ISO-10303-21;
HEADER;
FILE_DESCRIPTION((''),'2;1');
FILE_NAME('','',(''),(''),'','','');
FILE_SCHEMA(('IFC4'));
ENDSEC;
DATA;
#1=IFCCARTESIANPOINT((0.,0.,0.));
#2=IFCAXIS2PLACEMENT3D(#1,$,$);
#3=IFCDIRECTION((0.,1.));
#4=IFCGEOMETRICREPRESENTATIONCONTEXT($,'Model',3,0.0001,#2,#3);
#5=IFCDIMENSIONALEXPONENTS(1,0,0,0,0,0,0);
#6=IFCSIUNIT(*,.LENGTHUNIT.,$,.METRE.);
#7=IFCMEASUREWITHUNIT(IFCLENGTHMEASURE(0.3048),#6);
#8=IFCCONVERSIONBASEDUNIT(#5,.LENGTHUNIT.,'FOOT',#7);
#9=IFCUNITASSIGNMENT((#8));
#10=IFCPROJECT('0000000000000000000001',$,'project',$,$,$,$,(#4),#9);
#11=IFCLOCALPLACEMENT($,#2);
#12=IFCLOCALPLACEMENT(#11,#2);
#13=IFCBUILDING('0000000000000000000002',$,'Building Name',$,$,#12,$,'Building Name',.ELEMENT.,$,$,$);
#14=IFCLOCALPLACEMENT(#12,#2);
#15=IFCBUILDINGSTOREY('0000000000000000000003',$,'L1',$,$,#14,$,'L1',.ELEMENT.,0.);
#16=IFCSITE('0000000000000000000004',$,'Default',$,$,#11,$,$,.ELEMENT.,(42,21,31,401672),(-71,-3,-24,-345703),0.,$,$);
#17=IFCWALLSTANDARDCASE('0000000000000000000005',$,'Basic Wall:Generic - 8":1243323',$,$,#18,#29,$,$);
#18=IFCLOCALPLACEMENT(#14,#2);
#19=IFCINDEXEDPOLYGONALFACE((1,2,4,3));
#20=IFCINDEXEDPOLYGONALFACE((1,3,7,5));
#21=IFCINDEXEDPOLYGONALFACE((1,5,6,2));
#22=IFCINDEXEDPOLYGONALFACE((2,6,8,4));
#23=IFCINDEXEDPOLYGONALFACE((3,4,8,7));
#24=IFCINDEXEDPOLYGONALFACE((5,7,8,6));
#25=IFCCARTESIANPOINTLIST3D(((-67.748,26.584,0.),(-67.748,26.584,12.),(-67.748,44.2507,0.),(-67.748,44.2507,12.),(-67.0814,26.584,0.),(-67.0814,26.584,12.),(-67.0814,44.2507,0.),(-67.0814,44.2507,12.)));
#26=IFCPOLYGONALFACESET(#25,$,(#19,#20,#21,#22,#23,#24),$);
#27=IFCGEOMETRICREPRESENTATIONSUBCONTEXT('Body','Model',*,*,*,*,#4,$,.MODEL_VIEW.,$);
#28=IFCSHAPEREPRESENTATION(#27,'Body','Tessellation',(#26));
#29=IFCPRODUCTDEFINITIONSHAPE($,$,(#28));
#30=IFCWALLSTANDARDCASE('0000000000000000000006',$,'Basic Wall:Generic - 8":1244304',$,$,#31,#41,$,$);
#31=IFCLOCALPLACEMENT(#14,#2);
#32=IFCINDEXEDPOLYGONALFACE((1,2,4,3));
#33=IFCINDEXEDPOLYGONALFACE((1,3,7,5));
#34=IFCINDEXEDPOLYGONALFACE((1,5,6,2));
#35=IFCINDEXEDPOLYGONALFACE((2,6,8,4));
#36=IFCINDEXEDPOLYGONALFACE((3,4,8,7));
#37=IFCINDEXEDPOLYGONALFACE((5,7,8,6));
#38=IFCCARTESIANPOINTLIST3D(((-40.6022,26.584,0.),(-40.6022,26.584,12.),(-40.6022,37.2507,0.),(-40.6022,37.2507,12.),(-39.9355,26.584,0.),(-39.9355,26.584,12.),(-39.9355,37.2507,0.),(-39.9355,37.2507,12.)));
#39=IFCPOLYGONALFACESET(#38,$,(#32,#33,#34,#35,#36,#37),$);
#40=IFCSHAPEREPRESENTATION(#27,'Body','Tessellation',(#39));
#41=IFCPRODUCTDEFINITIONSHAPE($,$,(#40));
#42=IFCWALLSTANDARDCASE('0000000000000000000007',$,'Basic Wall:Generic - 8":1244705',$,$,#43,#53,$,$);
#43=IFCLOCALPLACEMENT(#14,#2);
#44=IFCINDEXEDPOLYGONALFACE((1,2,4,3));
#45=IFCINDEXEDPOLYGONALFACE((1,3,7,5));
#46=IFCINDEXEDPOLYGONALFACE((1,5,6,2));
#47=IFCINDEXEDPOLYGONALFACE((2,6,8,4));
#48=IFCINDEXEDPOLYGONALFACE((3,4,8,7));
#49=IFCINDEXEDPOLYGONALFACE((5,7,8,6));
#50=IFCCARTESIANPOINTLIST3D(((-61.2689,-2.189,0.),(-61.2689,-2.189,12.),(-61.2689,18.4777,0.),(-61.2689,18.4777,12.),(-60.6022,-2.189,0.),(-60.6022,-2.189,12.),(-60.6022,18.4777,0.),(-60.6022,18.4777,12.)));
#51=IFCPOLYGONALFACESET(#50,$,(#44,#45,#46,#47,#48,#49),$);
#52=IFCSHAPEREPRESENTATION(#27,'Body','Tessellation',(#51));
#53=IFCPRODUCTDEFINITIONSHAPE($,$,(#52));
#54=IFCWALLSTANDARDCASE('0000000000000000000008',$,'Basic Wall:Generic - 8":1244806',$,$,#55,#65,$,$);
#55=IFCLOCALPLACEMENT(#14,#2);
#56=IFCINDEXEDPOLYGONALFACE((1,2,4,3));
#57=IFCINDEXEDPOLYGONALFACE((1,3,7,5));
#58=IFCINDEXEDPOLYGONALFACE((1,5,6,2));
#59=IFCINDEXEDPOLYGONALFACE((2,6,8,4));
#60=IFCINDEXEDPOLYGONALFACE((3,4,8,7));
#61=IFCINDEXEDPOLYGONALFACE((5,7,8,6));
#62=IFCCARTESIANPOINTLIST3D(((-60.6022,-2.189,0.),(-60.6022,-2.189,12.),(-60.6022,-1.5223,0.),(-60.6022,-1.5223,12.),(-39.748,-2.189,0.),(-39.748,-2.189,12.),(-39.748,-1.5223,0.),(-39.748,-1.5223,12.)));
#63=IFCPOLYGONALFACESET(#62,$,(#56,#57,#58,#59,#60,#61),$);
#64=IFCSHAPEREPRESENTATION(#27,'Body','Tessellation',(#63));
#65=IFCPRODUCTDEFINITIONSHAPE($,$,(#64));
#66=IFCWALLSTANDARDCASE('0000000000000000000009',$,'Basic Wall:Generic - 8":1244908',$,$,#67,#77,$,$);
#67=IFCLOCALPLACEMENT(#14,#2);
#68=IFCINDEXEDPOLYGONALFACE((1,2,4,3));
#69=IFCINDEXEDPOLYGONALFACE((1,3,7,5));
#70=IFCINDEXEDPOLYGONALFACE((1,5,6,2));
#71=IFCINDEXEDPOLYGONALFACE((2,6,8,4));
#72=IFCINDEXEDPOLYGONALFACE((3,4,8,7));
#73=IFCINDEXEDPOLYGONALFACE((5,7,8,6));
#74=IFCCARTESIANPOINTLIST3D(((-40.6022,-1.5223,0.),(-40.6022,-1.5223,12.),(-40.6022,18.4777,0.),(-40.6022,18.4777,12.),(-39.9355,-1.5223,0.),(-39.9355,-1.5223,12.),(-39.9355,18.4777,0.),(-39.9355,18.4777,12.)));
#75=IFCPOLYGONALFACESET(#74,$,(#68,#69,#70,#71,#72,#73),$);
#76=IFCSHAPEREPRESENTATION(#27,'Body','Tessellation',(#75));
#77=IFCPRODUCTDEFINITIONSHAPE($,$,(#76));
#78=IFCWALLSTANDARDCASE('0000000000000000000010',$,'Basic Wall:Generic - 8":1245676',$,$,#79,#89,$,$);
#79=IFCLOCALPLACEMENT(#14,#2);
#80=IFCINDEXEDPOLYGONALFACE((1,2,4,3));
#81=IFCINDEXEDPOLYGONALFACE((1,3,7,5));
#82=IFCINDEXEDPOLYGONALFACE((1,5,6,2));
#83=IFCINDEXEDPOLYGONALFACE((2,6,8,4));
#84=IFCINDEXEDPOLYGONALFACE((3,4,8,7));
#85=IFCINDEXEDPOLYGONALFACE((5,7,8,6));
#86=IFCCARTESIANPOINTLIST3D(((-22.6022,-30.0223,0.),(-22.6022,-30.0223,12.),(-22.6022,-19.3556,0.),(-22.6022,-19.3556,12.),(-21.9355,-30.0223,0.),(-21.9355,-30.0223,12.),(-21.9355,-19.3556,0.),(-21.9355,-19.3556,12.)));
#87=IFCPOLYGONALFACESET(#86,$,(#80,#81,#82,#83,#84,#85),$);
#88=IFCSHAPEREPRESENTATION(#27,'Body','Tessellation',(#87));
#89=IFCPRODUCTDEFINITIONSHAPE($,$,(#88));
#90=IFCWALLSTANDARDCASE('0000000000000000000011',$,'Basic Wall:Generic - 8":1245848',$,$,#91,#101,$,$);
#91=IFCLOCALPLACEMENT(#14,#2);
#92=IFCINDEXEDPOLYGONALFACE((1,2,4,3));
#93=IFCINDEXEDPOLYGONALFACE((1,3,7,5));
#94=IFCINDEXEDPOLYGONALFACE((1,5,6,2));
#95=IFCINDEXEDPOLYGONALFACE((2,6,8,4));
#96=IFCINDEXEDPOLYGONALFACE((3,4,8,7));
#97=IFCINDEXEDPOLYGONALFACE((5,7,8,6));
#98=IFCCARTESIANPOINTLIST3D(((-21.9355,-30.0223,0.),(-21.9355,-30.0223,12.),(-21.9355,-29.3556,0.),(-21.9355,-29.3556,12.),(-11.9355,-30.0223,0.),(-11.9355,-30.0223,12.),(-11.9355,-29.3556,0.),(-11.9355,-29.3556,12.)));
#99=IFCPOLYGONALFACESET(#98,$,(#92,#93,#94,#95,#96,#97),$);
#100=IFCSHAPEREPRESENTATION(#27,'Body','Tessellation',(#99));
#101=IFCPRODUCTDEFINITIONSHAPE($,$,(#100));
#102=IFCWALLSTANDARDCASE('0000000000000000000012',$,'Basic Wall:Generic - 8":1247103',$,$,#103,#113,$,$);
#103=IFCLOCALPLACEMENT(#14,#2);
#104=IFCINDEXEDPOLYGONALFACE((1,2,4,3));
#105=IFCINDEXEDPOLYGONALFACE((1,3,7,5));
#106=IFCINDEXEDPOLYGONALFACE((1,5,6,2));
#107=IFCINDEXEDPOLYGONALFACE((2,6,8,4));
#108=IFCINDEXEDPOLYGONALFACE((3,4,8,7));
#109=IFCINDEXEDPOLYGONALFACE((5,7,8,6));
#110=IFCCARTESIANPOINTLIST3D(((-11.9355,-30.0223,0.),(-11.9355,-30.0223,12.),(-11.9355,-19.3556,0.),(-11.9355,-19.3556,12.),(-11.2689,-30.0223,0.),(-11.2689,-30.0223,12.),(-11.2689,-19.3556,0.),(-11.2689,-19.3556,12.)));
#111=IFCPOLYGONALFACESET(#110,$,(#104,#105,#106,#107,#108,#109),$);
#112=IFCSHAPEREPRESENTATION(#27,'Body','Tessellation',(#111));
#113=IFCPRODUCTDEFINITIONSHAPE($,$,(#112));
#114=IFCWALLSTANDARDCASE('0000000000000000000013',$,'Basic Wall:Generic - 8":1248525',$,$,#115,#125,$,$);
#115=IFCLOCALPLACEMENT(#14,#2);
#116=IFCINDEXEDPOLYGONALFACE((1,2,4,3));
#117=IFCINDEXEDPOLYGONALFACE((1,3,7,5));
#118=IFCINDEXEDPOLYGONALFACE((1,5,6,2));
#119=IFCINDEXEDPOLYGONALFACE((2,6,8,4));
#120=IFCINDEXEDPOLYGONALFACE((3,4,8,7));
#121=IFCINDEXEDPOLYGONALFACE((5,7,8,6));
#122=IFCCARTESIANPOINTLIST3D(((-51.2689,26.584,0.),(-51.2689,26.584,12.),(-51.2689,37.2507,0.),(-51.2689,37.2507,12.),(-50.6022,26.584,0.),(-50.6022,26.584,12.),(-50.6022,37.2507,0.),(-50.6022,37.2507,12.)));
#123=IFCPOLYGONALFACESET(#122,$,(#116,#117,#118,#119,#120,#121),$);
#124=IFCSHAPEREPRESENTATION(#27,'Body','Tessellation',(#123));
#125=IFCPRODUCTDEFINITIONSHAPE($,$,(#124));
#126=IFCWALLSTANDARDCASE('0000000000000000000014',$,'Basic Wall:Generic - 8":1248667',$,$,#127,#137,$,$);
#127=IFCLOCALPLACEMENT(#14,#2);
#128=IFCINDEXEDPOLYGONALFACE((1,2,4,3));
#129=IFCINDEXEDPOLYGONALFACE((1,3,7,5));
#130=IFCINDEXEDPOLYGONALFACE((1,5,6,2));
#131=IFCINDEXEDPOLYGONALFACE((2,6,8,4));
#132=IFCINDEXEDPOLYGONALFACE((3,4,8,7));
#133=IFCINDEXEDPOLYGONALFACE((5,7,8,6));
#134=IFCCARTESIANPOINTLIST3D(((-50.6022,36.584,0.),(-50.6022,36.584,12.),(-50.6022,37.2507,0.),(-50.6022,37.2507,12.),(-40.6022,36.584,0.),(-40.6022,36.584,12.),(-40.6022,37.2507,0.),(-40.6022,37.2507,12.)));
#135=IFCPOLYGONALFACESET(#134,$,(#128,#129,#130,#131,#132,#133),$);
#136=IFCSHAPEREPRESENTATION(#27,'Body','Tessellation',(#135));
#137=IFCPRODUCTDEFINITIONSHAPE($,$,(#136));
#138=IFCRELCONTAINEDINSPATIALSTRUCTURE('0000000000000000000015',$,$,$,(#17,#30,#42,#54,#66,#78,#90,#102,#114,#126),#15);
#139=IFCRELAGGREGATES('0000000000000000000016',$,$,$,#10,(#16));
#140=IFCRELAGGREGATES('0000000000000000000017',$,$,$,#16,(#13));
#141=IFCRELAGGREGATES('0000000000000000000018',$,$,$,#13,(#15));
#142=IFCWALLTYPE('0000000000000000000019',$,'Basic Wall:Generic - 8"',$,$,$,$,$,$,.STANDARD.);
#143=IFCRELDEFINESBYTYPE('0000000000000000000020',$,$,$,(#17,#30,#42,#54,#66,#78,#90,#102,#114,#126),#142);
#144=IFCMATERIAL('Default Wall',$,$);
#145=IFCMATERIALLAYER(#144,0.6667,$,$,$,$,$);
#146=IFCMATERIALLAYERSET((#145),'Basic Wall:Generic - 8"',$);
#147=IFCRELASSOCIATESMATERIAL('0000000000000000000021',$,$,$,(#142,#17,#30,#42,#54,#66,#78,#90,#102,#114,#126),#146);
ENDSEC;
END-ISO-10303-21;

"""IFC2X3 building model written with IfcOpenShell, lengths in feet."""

from ifc_helpers import new_model, entity, si_unit, converted_unit, direction, frame, frame_2d, origin, place, context, subcontext, project, spatial, rectangle, extrude, material, layer, layer_set, layer_usage, type_object, element, save


model = new_model("IFC2X3")

# Units and contexts
model_context = context("Model", 3, precision=0.0001, world=origin(), true_north=direction((0.0, 1.0)))
body_context = subcontext(model_context, "Body", "Model", "MODEL_VIEW")
ifc_project = project(units=[converted_unit("LENGTHUNIT", "FOOT", entity("IfcLengthMeasure", 0.3048), si_unit("LENGTHUNIT", "METRE"), dimensions=[1, 0, 0, 0, 0, 0, 0])], contexts=[model_context])

# Site, building, storey
site_placement = place(None, origin())
site = spatial("IfcSite", under=ifc_project, at=site_placement, Name="Default", CompositionType="ELEMENT", RefLatitude=(42, 21, 31, 401672), RefLongitude=(-71, -3, -24, -345703), RefElevation=0.0)
building_placement = place(site_placement, origin())
building = spatial("IfcBuilding", under=site, at=building_placement, Name="Building Name", LongName="Building Name", CompositionType="ELEMENT")
storey_placement = place(building_placement, origin())
storey = spatial("IfcBuildingStorey", under=building, at=storey_placement, Name="L1", LongName="L1", CompositionType="ELEMENT", Elevation=0.0)

# Walls
ifc_material_1 = material(Name="Default Wall")
ifc_layer_1 = layer(ifc_material_1, 0.6667)
ifc_layer_set_1 = layer_set([ifc_layer_1], Name="Basic Wall:Generic - 8\"")
wall_type_1 = type_object("IfcWallType", Name="Basic Wall:Generic - 8\"", PredefinedType="STANDARD", material=ifc_layer_set_1)
ifc_layer_usage_1 = layer_usage(ifc_layer_set_1, "AXIS2", "NEGATIVE", 0.3333)
wall_1_placement = place(storey_placement, frame((-67.4147, 44.2507, 0.0), z_axis=(0.0, 0.0, 1.0), x_axis=(0.0, -1.0, 0.0)))
element("IfcWallStandardCase", 1, at=wall_1_placement, inside=storey, type_object=wall_type_1, material=ifc_layer_usage_1, Name="Basic Wall:Generic - 8\":1243323", context=body_context, shape_type="SweptSolid", body=[
    extrude(rectangle(XDim=17.6667, YDim=0.6667, at=frame_2d((8.8333, 0.0), x_axis=(-1.0, 0.0))), origin(), (0.0, 0.0, 1.0), 12.0),
])
ifc_layer_usage_2 = layer_usage(ifc_layer_set_1, "AXIS2", "NEGATIVE", 0.3333)
wall_2_placement = place(storey_placement, frame((-40.2689, 26.584, 0.0), z_axis=(0.0, 0.0, 1.0), x_axis=(0.0, 1.0, 0.0)))
element("IfcWallStandardCase", 2, at=wall_2_placement, inside=storey, type_object=wall_type_1, material=ifc_layer_usage_2, Name="Basic Wall:Generic - 8\":1244304", context=body_context, shape_type="SweptSolid", body=[
    extrude(rectangle(XDim=10.6667, YDim=0.6667, at=frame_2d((5.3333, 0.0), x_axis=(-1.0, 0.0))), origin(), (0.0, 0.0, 1.0), 12.0),
])
ifc_layer_usage_3 = layer_usage(ifc_layer_set_1, "AXIS2", "NEGATIVE", 0.3333)
wall_3_placement = place(storey_placement, frame((-60.9355, 18.4777, 0.0), z_axis=(0.0, 0.0, 1.0), x_axis=(0.0, -1.0, 0.0)))
element("IfcWallStandardCase", 3, at=wall_3_placement, inside=storey, type_object=wall_type_1, material=ifc_layer_usage_3, Name="Basic Wall:Generic - 8\":1244705", context=body_context, shape_type="SweptSolid", body=[
    extrude(rectangle(XDim=20.6667, YDim=0.6667, at=frame_2d((10.3333, 0.0), x_axis=(-1.0, 0.0))), origin(), (0.0, 0.0, 1.0), 12.0),
])
ifc_layer_usage_4 = layer_usage(ifc_layer_set_1, "AXIS2", "NEGATIVE", 0.3333)
wall_4_placement = place(storey_placement, frame((-60.6022, -1.8556, 0.0)))
element("IfcWallStandardCase", 4, at=wall_4_placement, inside=storey, type_object=wall_type_1, material=ifc_layer_usage_4, Name="Basic Wall:Generic - 8\":1244806", context=body_context, shape_type="SweptSolid", body=[
    extrude(rectangle(XDim=20.8542, YDim=0.6667, at=frame_2d((10.4271, 0.0), x_axis=(-1.0, 0.0))), origin(), (0.0, 0.0, 1.0), 12.0),
])
ifc_layer_usage_5 = layer_usage(ifc_layer_set_1, "AXIS2", "POSITIVE", -0.3333)
wall_5_placement = place(storey_placement, frame((-40.2689, 18.4777, 0.0), z_axis=(0.0, 0.0, 1.0), x_axis=(0.0, -1.0, 0.0)))
element("IfcWallStandardCase", 5, at=wall_5_placement, inside=storey, type_object=wall_type_1, material=ifc_layer_usage_5, Name="Basic Wall:Generic - 8\":1244908", context=body_context, shape_type="SweptSolid", body=[
    extrude(rectangle(XDim=20.0, YDim=0.6667, at=frame_2d((10.0, 0.0), x_axis=(-1.0, 0.0))), origin(), (0.0, 0.0, 1.0), 12.0),
])
ifc_layer_usage_6 = layer_usage(ifc_layer_set_1, "AXIS2", "POSITIVE", -0.3333)
wall_6_placement = place(storey_placement, frame((-22.2689, -19.3556, 0.0), z_axis=(0.0, 0.0, 1.0), x_axis=(0.0, -1.0, 0.0)))
element("IfcWallStandardCase", 6, at=wall_6_placement, inside=storey, type_object=wall_type_1, material=ifc_layer_usage_6, Name="Basic Wall:Generic - 8\":1245676", context=body_context, shape_type="SweptSolid", body=[
    extrude(rectangle(XDim=10.6667, YDim=0.6667, at=frame_2d((5.3333, 0.0), x_axis=(-1.0, 0.0))), origin(), (0.0, 0.0, 1.0), 12.0),
])
ifc_layer_usage_7 = layer_usage(ifc_layer_set_1, "AXIS2", "POSITIVE", -0.3333)
wall_7_placement = place(storey_placement, frame((-21.9355, -29.689, 0.0)))
element("IfcWallStandardCase", 7, at=wall_7_placement, inside=storey, type_object=wall_type_1, material=ifc_layer_usage_7, Name="Basic Wall:Generic - 8\":1245848", context=body_context, shape_type="SweptSolid", body=[
    extrude(rectangle(XDim=10.0, YDim=0.6667, at=frame_2d((5.0, 0.0), x_axis=(-1.0, 0.0))), origin(), (0.0, 0.0, 1.0), 12.0),
])
ifc_layer_usage_8 = layer_usage(ifc_layer_set_1, "AXIS2", "NEGATIVE", 0.3333)
wall_8_placement = place(storey_placement, frame((-11.6022, -19.3556, 0.0), z_axis=(0.0, 0.0, 1.0), x_axis=(0.0, -1.0, 0.0)))
element("IfcWallStandardCase", 8, at=wall_8_placement, inside=storey, type_object=wall_type_1, material=ifc_layer_usage_8, Name="Basic Wall:Generic - 8\":1247103", context=body_context, shape_type="SweptSolid", body=[
    extrude(rectangle(XDim=10.6667, YDim=0.6667, at=frame_2d((5.3333, 0.0), x_axis=(-1.0, 0.0))), origin(), (0.0, 0.0, 1.0), 12.0),
])
ifc_layer_usage_9 = layer_usage(ifc_layer_set_1, "AXIS2", "NEGATIVE", 0.3333)
wall_9_placement = place(storey_placement, frame((-50.9355, 26.584, 0.0), z_axis=(0.0, 0.0, 1.0), x_axis=(0.0, 1.0, 0.0)))
element("IfcWallStandardCase", 9, at=wall_9_placement, inside=storey, type_object=wall_type_1, material=ifc_layer_usage_9, Name="Basic Wall:Generic - 8\":1248525", context=body_context, shape_type="SweptSolid", body=[
    extrude(rectangle(XDim=10.6667, YDim=0.6667, at=frame_2d((5.3333, 0.0), x_axis=(-1.0, 0.0))), origin(), (0.0, 0.0, 1.0), 12.0),
])
ifc_layer_usage_10 = layer_usage(ifc_layer_set_1, "AXIS2", "POSITIVE", -0.3333)
wall_10_placement = place(storey_placement, frame((-50.6022, 36.9174, 0.0)))
element("IfcWallStandardCase", 10, at=wall_10_placement, inside=storey, type_object=wall_type_1, material=ifc_layer_usage_10, Name="Basic Wall:Generic - 8\":1248667", context=body_context, shape_type="SweptSolid", body=[
    extrude(rectangle(XDim=10.0, YDim=0.6667, at=frame_2d((5.0, 0.0), x_axis=(-1.0, 0.0))), origin(), (0.0, 0.0, 1.0), 12.0),
])

save(model, "model.ifc")
